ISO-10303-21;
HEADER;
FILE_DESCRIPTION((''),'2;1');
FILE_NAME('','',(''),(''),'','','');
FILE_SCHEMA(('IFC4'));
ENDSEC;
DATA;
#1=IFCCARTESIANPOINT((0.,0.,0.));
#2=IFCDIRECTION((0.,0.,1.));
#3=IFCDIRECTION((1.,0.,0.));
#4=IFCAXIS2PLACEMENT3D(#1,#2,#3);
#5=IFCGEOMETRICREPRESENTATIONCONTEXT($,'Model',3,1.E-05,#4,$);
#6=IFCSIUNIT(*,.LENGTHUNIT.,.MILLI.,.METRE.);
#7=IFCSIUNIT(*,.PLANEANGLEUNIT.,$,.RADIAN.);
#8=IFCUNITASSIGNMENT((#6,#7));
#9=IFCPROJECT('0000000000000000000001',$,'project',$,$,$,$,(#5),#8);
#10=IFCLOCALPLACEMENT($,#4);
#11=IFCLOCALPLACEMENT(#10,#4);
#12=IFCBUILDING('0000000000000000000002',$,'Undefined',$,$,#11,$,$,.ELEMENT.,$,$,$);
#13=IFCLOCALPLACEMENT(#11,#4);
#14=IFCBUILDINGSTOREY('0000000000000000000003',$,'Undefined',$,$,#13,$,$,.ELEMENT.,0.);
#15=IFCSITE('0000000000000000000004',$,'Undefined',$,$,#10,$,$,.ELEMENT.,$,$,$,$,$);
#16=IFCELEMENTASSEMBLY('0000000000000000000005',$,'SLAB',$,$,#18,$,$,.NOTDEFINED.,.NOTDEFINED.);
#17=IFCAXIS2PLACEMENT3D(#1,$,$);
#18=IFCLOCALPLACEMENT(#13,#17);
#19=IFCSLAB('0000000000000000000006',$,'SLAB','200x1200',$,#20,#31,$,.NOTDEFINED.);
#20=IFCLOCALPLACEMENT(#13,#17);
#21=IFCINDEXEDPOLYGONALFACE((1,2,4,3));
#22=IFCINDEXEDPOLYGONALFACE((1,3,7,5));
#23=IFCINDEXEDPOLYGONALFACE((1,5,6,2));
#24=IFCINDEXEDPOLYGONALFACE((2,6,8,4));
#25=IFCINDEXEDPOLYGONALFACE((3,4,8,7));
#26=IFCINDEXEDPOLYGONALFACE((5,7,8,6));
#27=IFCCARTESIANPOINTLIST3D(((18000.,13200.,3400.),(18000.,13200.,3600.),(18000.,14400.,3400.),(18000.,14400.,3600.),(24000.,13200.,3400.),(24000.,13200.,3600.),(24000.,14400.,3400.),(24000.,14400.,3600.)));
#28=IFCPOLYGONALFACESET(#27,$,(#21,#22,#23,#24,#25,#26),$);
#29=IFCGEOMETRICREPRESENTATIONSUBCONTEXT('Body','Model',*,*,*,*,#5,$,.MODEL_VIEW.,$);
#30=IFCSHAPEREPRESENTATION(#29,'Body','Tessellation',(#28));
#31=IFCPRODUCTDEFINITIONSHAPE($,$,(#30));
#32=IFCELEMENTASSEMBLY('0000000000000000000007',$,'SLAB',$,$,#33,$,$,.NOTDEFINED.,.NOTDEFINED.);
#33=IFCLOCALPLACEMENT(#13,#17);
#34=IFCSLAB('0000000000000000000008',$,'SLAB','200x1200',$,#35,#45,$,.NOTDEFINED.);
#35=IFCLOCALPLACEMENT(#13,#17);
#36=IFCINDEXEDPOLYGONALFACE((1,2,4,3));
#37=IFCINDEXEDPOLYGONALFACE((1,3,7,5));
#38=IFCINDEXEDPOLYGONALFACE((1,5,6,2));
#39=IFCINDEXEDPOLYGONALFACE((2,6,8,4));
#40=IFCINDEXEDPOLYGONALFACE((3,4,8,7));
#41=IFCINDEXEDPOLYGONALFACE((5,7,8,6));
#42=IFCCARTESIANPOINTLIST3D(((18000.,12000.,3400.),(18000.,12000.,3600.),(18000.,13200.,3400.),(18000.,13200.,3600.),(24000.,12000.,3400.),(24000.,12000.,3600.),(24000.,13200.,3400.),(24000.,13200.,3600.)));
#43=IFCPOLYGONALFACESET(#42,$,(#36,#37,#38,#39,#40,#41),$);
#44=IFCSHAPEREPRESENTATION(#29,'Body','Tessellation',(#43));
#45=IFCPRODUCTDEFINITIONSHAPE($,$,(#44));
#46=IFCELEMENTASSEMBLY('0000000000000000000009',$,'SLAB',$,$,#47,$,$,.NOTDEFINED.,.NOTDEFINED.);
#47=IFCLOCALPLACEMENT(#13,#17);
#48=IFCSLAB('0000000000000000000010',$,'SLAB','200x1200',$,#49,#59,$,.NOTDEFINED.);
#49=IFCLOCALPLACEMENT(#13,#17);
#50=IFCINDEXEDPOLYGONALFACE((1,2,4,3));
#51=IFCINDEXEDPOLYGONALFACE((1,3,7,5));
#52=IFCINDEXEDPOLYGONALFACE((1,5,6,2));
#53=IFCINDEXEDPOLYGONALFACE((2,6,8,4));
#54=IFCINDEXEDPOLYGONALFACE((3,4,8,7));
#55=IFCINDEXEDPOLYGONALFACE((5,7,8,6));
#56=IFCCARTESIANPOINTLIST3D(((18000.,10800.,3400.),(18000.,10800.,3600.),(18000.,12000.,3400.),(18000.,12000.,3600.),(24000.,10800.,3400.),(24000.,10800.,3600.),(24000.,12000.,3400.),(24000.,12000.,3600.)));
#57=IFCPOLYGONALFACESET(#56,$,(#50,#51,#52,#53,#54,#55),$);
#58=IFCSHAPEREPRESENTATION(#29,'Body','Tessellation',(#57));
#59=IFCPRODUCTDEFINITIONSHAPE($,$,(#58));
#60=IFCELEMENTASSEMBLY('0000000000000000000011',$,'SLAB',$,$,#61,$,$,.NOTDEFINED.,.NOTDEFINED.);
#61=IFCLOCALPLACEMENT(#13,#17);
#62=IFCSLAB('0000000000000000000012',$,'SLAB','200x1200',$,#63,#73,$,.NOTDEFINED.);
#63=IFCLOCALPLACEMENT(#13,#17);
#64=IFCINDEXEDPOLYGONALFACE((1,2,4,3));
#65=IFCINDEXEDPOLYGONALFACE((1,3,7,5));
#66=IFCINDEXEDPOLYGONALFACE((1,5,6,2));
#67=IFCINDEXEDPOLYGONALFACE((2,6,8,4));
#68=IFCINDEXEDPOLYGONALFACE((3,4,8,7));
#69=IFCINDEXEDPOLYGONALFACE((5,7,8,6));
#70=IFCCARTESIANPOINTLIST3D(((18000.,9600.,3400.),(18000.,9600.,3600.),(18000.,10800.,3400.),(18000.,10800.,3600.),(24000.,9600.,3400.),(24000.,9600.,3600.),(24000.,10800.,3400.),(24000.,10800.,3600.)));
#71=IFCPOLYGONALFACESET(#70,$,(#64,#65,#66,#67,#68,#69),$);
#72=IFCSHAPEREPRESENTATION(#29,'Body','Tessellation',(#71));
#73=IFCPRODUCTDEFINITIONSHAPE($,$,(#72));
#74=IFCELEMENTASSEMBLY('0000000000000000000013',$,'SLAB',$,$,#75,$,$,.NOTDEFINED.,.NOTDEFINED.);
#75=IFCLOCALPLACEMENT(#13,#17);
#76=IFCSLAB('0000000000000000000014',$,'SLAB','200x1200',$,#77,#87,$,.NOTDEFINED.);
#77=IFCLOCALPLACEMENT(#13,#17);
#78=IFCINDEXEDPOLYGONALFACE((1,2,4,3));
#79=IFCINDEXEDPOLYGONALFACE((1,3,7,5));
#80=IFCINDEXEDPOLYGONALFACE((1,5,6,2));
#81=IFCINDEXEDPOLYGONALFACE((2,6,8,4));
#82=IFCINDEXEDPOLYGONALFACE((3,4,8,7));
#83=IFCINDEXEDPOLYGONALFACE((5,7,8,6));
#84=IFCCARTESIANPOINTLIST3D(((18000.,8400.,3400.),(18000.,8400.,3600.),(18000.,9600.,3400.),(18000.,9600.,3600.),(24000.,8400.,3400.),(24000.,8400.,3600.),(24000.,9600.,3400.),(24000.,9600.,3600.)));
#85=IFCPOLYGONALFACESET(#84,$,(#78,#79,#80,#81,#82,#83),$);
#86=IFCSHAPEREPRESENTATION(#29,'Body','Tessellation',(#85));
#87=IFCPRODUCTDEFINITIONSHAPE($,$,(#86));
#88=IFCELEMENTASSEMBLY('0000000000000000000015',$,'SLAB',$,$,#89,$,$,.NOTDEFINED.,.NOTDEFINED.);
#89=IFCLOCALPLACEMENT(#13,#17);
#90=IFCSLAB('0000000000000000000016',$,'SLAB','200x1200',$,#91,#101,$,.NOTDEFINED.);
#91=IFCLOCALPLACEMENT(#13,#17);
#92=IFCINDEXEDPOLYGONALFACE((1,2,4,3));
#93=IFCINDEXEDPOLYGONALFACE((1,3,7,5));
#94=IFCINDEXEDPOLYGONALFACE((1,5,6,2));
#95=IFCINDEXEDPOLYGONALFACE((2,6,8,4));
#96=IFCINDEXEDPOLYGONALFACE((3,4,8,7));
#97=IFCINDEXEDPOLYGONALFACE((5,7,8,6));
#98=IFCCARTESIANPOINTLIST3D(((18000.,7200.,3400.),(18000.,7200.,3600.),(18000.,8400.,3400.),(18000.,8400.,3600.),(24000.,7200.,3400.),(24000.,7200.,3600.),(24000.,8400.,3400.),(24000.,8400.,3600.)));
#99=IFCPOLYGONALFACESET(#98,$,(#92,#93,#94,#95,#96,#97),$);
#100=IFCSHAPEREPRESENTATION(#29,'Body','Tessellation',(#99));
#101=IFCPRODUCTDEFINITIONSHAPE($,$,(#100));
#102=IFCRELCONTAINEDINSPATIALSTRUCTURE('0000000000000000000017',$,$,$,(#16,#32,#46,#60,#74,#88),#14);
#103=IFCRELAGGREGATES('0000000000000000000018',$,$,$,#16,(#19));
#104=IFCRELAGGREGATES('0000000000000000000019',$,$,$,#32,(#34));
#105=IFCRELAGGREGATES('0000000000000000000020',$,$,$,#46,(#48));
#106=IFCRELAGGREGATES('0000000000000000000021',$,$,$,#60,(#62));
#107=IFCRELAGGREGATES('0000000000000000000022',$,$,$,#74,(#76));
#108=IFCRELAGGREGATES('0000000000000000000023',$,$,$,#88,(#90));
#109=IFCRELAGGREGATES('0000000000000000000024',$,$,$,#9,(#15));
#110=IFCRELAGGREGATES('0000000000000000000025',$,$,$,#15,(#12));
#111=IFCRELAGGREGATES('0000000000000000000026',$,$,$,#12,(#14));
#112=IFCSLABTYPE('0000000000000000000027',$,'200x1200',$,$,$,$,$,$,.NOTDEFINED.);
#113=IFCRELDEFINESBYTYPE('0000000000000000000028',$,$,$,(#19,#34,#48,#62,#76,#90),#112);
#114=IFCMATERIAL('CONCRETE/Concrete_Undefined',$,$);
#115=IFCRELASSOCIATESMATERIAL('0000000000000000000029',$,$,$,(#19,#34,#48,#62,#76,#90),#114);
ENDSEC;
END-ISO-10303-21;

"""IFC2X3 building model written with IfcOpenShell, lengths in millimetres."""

from ifc_helpers import new_model, si_unit, frame, origin_with_axes, place, context, subcontext, project, spatial, polyline, outline, extrude, material, type_object, element, aggregate, save


model = new_model("IFC2X3")

# Units and contexts
model_context = context("Model", 3, precision=1e-05, world=origin_with_axes())
body_context = subcontext(model_context, "Body", "Model", "MODEL_VIEW")
ifc_project = project(units=[si_unit("LENGTHUNIT", "METRE", prefix="MILLI"), si_unit("PLANEANGLEUNIT", "RADIAN")], contexts=[model_context])

# Site, building, storey
site_placement = place(None, origin_with_axes())
site = spatial("IfcSite", under=ifc_project, at=site_placement, Name="Undefined", CompositionType="ELEMENT")
building_placement = place(site_placement, origin_with_axes())
building = spatial("IfcBuilding", under=site, at=building_placement, Name="Undefined", CompositionType="ELEMENT")
storey_placement = place(building_placement, origin_with_axes())
storey = spatial("IfcBuildingStorey", under=building, at=storey_placement, Name="Undefined", CompositionType="ELEMENT", Elevation=0.0)

# Shared definitions
ifc_material_1 = material(Name="CONCRETE/Concrete_Undefined")

# Element assemblies, slabs
slab_type = type_object("IfcSlabType", Name="200x1200", PredefinedType="NOTDEFINED")
assembly_1_placement = place(storey_placement, origin_with_axes())
assembly_1 = element("IfcElementAssembly", 1, at=assembly_1_placement, inside=storey, Name="SLAB", AssemblyPlace="NOTDEFINED", PredefinedType="NOTDEFINED")
slab_1_placement = place(assembly_1_placement, frame((24000.0, 13200.0, 3500.0), z_axis=(0.0, 0.0, 1.0), x_axis=(0.0, 1.0, 0.0)))
slab_1 = element("IfcSlab", 2, at=slab_1_placement, type_object=slab_type, material=ifc_material_1, Name="SLAB", Description="200x1200", PredefinedType="NOTDEFINED", context=body_context, shape_type="SweptSolid", body=[
    extrude(outline(polyline([(0.0, 0.0), (1200.0, 0.0), (1200.0, 6000.0), (0.0, 6000.0), (0.0, 0.0)])), frame((0.0, 0.0, -100.0), z_axis=(0.0, 0.0, 1.0), x_axis=(1.0, 0.0, 0.0)), (0.0, 0.0, 1.0), 200.0),
])
aggregate(assembly_1, [slab_1])
assembly_2_placement = place(storey_placement, origin_with_axes())
assembly_2 = element("IfcElementAssembly", 3, at=assembly_2_placement, inside=storey, Name="SLAB", AssemblyPlace="NOTDEFINED", PredefinedType="NOTDEFINED")
slab_2_placement = place(assembly_2_placement, frame((24000.0, 12000.0, 3500.0), z_axis=(0.0, 0.0, 1.0), x_axis=(0.0, 1.0, 0.0)))
slab_2 = element("IfcSlab", 4, at=slab_2_placement, type_object=slab_type, material=ifc_material_1, Name="SLAB", Description="200x1200", PredefinedType="NOTDEFINED", context=body_context, shape_type="SweptSolid", body=[
    extrude(outline(polyline([(0.0, 0.0), (1200.0, 0.0), (1200.0, 6000.0), (0.0, 6000.0), (0.0, 0.0)])), frame((0.0, 0.0, -100.0), z_axis=(0.0, 0.0, 1.0), x_axis=(1.0, 0.0, 0.0)), (0.0, 0.0, 1.0), 200.0),
])
aggregate(assembly_2, [slab_2])
assembly_3_placement = place(storey_placement, origin_with_axes())
assembly_3 = element("IfcElementAssembly", 5, at=assembly_3_placement, inside=storey, Name="SLAB", AssemblyPlace="NOTDEFINED", PredefinedType="NOTDEFINED")
slab_3_placement = place(assembly_3_placement, frame((24000.0, 10800.0, 3500.0), z_axis=(0.0, 0.0, 1.0), x_axis=(0.0, 1.0, 0.0)))
slab_3 = element("IfcSlab", 6, at=slab_3_placement, type_object=slab_type, material=ifc_material_1, Name="SLAB", Description="200x1200", PredefinedType="NOTDEFINED", context=body_context, shape_type="SweptSolid", body=[
    extrude(outline(polyline([(0.0, 0.0), (1200.0, 0.0), (1200.0, 6000.0), (0.0, 6000.0), (0.0, 0.0)])), frame((0.0, 0.0, -100.0), z_axis=(0.0, 0.0, 1.0), x_axis=(1.0, 0.0, 0.0)), (0.0, 0.0, 1.0), 200.0),
])
aggregate(assembly_3, [slab_3])
assembly_4_placement = place(storey_placement, origin_with_axes())
assembly_4 = element("IfcElementAssembly", 7, at=assembly_4_placement, inside=storey, Name="SLAB", AssemblyPlace="NOTDEFINED", PredefinedType="NOTDEFINED")
slab_4_placement = place(assembly_4_placement, frame((24000.0, 9600.0, 3500.0), z_axis=(0.0, 0.0, 1.0), x_axis=(0.0, 1.0, 0.0)))
slab_4 = element("IfcSlab", 8, at=slab_4_placement, type_object=slab_type, material=ifc_material_1, Name="SLAB", Description="200x1200", PredefinedType="NOTDEFINED", context=body_context, shape_type="SweptSolid", body=[
    extrude(outline(polyline([(0.0, 0.0), (1200.0, 0.0), (1200.0, 6000.0), (0.0, 6000.0), (0.0, 0.0)])), frame((0.0, 0.0, -100.0), z_axis=(0.0, 0.0, 1.0), x_axis=(1.0, 0.0, 0.0)), (0.0, 0.0, 1.0), 200.0),
])
aggregate(assembly_4, [slab_4])
assembly_5_placement = place(storey_placement, origin_with_axes())
assembly_5 = element("IfcElementAssembly", 9, at=assembly_5_placement, inside=storey, Name="SLAB", AssemblyPlace="NOTDEFINED", PredefinedType="NOTDEFINED")
slab_5_placement = place(assembly_5_placement, frame((24000.0, 8400.0, 3500.0), z_axis=(0.0, 0.0, 1.0), x_axis=(0.0, 1.0, 0.0)))
slab_5 = element("IfcSlab", 10, at=slab_5_placement, type_object=slab_type, material=ifc_material_1, Name="SLAB", Description="200x1200", PredefinedType="NOTDEFINED", context=body_context, shape_type="SweptSolid", body=[
    extrude(outline(polyline([(0.0, 0.0), (1200.0, 0.0), (1200.0, 6000.0), (0.0, 6000.0), (0.0, 0.0)])), frame((0.0, 0.0, -100.0), z_axis=(0.0, 0.0, 1.0), x_axis=(1.0, 0.0, 0.0)), (0.0, 0.0, 1.0), 200.0),
])
aggregate(assembly_5, [slab_5])
assembly_6_placement = place(storey_placement, origin_with_axes())
assembly_6 = element("IfcElementAssembly", 11, at=assembly_6_placement, inside=storey, Name="SLAB", AssemblyPlace="NOTDEFINED", PredefinedType="NOTDEFINED")
slab_6_placement = place(assembly_6_placement, frame((24000.0, 7200.0, 3500.0), z_axis=(0.0, 0.0, 1.0), x_axis=(0.0, 1.0, 0.0)))
slab_6 = element("IfcSlab", 12, at=slab_6_placement, type_object=slab_type, material=ifc_material_1, Name="SLAB", Description="200x1200", PredefinedType="NOTDEFINED", context=body_context, shape_type="SweptSolid", body=[
    extrude(outline(polyline([(0.0, 0.0), (1200.0, 0.0), (1200.0, 6000.0), (0.0, 6000.0), (0.0, 0.0)])), frame((0.0, 0.0, -100.0), z_axis=(0.0, 0.0, 1.0), x_axis=(1.0, 0.0, 0.0)), (0.0, 0.0, 1.0), 200.0),
])
aggregate(assembly_6, [slab_6])

save(model, "model.ifc")
